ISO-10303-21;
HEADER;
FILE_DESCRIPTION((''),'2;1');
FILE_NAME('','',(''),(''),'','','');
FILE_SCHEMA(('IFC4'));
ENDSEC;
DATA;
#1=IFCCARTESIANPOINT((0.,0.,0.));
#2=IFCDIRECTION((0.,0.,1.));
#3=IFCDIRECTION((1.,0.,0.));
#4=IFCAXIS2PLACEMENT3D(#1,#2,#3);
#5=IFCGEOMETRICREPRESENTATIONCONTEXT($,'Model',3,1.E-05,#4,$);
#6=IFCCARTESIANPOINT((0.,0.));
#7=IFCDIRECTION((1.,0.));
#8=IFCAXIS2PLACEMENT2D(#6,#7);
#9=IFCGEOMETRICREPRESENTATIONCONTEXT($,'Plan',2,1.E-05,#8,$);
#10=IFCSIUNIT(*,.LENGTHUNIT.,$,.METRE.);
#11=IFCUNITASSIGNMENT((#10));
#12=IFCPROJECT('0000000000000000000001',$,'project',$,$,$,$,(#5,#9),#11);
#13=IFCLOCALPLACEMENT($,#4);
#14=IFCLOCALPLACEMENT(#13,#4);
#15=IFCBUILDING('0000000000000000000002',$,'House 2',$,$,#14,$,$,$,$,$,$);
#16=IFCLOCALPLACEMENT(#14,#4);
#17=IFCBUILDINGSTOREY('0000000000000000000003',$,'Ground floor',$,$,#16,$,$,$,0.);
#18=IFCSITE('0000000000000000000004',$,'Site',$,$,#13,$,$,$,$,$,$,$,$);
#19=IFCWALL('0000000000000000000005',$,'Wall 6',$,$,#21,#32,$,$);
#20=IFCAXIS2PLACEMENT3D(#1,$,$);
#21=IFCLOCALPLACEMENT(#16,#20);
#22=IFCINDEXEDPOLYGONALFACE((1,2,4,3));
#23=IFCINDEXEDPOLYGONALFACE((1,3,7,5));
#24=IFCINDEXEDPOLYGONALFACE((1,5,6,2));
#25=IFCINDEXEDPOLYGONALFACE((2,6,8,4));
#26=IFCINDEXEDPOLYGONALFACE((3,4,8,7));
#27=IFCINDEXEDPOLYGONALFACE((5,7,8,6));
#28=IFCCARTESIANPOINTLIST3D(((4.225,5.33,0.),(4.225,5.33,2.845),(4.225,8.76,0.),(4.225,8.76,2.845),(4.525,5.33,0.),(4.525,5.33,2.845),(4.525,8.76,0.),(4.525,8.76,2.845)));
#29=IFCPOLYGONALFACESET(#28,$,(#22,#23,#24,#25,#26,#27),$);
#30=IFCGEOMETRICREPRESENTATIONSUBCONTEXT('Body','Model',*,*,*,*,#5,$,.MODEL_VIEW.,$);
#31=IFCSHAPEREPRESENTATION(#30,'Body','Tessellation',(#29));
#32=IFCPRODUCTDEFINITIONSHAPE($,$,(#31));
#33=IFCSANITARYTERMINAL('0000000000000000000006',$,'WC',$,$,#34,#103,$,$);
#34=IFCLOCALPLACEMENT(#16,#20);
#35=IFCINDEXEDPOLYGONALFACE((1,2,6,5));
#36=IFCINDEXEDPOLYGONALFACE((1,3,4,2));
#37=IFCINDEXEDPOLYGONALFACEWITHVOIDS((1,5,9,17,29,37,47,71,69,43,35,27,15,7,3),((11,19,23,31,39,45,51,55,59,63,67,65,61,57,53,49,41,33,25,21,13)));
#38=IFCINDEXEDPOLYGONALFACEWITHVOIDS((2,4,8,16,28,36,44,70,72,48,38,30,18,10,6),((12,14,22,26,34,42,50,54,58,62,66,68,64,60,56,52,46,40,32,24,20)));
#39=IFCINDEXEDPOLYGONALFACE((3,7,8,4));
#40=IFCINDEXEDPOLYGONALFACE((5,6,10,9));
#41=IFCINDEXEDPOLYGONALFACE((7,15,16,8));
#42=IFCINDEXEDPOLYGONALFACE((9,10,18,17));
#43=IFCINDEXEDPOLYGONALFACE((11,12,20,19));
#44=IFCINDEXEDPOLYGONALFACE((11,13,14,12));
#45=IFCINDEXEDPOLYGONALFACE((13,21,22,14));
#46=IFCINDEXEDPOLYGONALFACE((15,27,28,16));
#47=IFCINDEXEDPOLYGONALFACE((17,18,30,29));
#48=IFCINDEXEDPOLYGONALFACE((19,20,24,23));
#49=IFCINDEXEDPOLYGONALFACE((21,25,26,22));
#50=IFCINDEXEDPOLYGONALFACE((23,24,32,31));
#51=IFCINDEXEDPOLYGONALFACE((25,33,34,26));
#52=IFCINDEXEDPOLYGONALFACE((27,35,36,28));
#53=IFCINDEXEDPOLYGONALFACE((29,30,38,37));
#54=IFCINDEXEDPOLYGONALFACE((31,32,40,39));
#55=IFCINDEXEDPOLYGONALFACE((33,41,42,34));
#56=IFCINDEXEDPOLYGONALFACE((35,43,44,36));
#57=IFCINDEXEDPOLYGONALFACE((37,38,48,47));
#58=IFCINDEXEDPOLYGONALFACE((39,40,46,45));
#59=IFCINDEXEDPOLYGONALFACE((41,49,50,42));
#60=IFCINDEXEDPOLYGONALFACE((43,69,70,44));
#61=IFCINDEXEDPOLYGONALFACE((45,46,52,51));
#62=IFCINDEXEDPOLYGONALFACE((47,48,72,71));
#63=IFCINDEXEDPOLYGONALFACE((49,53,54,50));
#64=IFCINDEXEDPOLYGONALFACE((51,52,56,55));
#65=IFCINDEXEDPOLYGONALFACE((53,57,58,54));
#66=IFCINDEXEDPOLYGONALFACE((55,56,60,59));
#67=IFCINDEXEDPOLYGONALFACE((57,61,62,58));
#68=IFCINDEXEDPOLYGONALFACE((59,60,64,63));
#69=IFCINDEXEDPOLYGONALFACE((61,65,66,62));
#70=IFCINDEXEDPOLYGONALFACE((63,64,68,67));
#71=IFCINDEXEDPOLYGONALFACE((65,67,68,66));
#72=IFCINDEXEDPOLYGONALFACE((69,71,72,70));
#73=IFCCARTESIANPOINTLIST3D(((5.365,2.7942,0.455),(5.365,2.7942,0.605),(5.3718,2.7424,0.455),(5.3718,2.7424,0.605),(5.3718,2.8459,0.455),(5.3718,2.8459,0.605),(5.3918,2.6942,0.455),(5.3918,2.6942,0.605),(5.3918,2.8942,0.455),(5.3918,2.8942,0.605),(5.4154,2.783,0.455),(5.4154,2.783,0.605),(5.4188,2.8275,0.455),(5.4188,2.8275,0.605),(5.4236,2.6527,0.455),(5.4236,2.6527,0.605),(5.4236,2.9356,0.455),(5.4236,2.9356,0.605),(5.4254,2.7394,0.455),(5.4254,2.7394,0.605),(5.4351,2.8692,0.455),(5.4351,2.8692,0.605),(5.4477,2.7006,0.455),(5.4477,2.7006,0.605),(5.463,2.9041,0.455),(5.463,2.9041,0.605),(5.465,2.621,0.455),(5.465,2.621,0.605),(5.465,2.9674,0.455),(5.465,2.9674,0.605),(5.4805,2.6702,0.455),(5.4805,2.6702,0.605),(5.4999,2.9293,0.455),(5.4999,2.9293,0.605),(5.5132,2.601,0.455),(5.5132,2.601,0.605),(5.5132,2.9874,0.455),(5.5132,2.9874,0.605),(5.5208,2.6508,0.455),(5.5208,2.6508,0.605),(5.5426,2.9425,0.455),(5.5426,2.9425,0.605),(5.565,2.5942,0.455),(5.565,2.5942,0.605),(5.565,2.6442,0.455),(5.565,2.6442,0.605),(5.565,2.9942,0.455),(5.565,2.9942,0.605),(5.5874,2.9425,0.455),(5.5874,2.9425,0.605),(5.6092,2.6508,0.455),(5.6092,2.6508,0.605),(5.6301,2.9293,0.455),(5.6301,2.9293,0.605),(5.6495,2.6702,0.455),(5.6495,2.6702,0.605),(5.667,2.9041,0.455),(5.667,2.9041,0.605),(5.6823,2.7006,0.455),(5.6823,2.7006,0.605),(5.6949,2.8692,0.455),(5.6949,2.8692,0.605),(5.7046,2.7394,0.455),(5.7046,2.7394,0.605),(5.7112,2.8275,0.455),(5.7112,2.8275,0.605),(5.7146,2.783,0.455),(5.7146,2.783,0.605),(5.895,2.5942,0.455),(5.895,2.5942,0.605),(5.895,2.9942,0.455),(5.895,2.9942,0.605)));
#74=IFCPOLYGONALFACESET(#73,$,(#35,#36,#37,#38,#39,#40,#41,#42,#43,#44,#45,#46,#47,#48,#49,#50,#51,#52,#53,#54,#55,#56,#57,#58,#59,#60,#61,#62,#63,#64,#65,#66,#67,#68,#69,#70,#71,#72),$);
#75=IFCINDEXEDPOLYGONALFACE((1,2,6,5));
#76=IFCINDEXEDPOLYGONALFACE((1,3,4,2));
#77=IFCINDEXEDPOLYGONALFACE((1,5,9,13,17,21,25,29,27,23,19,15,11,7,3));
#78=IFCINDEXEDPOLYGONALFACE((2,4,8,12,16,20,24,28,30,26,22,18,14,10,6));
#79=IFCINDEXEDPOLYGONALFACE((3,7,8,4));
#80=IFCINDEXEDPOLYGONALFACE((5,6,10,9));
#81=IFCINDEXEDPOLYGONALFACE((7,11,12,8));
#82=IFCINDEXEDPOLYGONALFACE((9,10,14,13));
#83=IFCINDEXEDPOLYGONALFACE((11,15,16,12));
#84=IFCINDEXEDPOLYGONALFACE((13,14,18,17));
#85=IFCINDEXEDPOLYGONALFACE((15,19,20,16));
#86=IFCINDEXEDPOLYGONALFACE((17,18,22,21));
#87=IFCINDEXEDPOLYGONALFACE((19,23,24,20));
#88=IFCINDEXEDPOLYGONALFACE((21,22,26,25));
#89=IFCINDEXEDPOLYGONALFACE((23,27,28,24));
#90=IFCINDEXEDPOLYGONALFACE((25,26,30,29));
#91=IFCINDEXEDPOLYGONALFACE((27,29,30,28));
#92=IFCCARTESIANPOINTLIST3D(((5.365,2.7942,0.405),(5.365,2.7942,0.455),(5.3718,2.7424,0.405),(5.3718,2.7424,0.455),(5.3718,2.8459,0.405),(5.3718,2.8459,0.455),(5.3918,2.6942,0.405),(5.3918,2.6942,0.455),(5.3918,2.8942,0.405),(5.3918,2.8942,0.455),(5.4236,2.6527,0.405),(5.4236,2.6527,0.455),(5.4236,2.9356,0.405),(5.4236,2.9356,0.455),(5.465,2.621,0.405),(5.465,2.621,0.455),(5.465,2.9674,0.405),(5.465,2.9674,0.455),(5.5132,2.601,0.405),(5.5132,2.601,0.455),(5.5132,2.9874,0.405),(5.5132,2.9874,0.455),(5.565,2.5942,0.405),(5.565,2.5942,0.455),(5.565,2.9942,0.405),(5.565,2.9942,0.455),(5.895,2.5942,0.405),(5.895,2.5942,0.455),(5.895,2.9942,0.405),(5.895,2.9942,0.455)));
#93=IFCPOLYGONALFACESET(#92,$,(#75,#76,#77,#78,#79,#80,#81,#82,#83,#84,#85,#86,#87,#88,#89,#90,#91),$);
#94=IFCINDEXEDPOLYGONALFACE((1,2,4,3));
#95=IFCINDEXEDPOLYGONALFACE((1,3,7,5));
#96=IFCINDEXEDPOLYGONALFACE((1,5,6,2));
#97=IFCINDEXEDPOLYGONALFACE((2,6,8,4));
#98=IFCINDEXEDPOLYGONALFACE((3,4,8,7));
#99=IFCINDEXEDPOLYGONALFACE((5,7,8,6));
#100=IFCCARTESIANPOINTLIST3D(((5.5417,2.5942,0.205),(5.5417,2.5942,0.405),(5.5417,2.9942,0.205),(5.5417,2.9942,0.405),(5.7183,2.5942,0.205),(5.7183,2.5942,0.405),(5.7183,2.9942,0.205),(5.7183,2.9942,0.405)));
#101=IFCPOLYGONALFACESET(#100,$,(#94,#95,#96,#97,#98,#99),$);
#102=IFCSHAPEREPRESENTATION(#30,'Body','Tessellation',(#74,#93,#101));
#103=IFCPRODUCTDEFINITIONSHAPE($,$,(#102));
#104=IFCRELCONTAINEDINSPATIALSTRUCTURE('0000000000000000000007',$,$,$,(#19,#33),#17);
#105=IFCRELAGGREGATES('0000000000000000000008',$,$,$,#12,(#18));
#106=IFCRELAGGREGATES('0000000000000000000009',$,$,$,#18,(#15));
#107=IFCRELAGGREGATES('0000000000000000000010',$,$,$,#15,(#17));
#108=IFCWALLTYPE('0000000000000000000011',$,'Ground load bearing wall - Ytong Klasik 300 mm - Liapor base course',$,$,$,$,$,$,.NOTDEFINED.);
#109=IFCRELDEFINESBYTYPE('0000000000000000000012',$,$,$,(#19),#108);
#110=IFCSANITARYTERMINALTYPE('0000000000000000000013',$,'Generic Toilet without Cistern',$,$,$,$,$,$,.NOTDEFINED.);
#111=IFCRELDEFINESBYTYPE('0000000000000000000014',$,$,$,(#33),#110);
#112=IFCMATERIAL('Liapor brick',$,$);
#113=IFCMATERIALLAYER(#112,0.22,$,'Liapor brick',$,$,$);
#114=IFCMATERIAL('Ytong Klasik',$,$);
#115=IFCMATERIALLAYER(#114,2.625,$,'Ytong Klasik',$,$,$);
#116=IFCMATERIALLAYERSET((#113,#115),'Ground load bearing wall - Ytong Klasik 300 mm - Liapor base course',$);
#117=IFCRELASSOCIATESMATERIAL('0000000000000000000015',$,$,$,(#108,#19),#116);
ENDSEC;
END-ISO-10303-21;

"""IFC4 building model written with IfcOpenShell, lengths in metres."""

from ifc_helpers import new_model, entity, si_unit, frame, frame_2d, origin_with_axes, origin_2d_with_axis, place, context, subcontext, project, spatial, line, arc, indexed_curve, circle_curve, outline, extrude, shape, source, transform, mapped, material, layer, layer_set, layer_usage, type_object, type_shapes, element, save


model = new_model("IFC4")

# Units and contexts
model_context = context("Model", 3, precision=1e-05, world=origin_with_axes())
plan_context = context("Plan", 2, precision=1e-05, world=origin_2d_with_axis())
body_context_1 = subcontext(model_context, "Body", "Model", "MODEL_VIEW")
body_context_2 = subcontext(plan_context, "Body", "Plan", "PLAN_VIEW")
ifc_project = project(units=[si_unit("LENGTHUNIT", "METRE")], contexts=[model_context, plan_context])

# Site, building, storey
site_placement = place(None, origin_with_axes())
site = spatial("IfcSite", under=ifc_project, at=site_placement, Name="Site")
building_placement = place(site_placement, origin_with_axes())
building = spatial("IfcBuilding", under=site, at=building_placement, Name="House 2")
storey_placement = place(building_placement, origin_with_axes())
storey = spatial("IfcBuildingStorey", under=building, at=storey_placement, Name="Ground floor", Elevation=0.0)

# Shared definitions
ifc_material_1 = material(Name="Liapor brick")

# Wall
ifc_layer_1 = layer(ifc_material_1, 0.22, Name="Liapor brick")
ifc_material_2 = material(Name="Ytong Klasik")
ifc_layer_2 = layer(ifc_material_2, 2.625, Name="Ytong Klasik")
ifc_layer_set_1 = layer_set([ifc_layer_1, ifc_layer_2], Name="Ground load bearing wall - Ytong Klasik 300 mm - Liapor base course")
ifc_layer_usage_1 = layer_usage(ifc_layer_set_1, "AXIS3", "POSITIVE", 0.0)
wall_type_1 = type_object("IfcWallType", Name="Ground load bearing wall - Ytong Klasik 300 mm - Liapor base course", PredefinedType="NOTDEFINED", material=ifc_layer_set_1)
wall_1_placement = place(storey_placement, frame((4.375, 5.33, 0.0), z_axis=(0.0, 0.0, 1.0), x_axis=(0.0, 1.0, 0.0)))
element("IfcWall", 1, at=wall_1_placement, inside=storey, type_object=wall_type_1, material=ifc_layer_usage_1, Name="Wall 6", context=body_context_1, shape_type="SweptSolid", body=[
    extrude(outline(indexed_curve([(0.0, 0.0), (0.0, 0.3), (3.43, 0.3), (3.43, 0.0), (0.0, 0.0)], self_intersect=False)), frame((0.0, -0.15, 0.0), z_axis=(0.0, 0.0, 1.0), x_axis=(1.0, 0.0, 0.0)), (0.0, 0.0, 1.0), 2.845),
])

# Sanitary terminal
sanitary_terminal_type_1 = type_object("IfcSanitaryTerminalType", Name="Generic Toilet without Cistern", PredefinedType="NOTDEFINED")
shared_shape_1 = source(origin_with_axes(), body_context_1, "Body", "SweptSolid", [
    extrude(outline(indexed_curve([(-0.2, 0.0), (0.2, 0.0), (0.2, -0.33), (0.1414, -0.4714), (0.0, -0.53), (-0.1414, -0.4714), (-0.2, -0.33)], segments=[line(1, 2), line(2, 3), arc(3, 4, 5), arc(5, 6, 7), line(7, 1)]), holes=[circle_curve(frame_2d((0.0, -0.33)), 0.15)]), frame((0.0, 0.0, 0.25), z_axis=(0.0, 0.0, 1.0), x_axis=(1.0, 0.0, 0.0)), (0.0, 0.0, 1.0), 0.15),
    extrude(outline(indexed_curve([(-0.2, 0.0), (0.2, 0.0), (0.2, -0.33), (0.1414, -0.4714), (0.0, -0.53), (-0.1414, -0.4714), (-0.2, -0.33)], segments=[line(1, 2), line(2, 3), arc(3, 4, 5), arc(5, 6, 7), line(7, 1)])), frame((0.0, 0.0, 0.2), z_axis=(0.0, 0.0, 1.0), x_axis=(1.0, 0.0, 0.0)), (0.0, 0.0, 1.0), 0.05),
    extrude(outline(indexed_curve([(-0.2, -0.1767), (0.2, -0.1767), (0.2, -0.3533), (-0.2, -0.3533)], segments=[line(1, 2, 3, 4, 1)])), origin_with_axes(), (0.0, 0.0, 1.0), 0.2),
])
shared_shape_2 = source(origin_with_axes(), body_context_2, "Body", "Curve2D", [
    entity("IfcIndexedPolyCurve", entity("IfcCartesianPointList2D", [[-0.12, 0.0], [0.12, 0.0]])),
    entity("IfcIndexedPolyCurve", entity("IfcCartesianPointList2D", [[0.12, 0.0], [0.2, -0.159]])),
    entity("IfcTrimmedCurve", entity("IfcEllipse", entity("IfcAxis2Placement2D", entity("IfcCartesianPoint", [0.0, -0.159]), entity("IfcDirection", [1.0, 0.0])), 0.2, 0.371), [entity("IfcCartesianPoint", [-0.2, -0.159])], [entity("IfcCartesianPoint", [0.2, -0.159])], True, "CARTESIAN"),
    entity("IfcIndexedPolyCurve", entity("IfcCartesianPointList2D", [[-0.12, 0.0], [-0.2, -0.159]])),
    entity("IfcEllipse", entity("IfcAxis2Placement2D", entity("IfcCartesianPoint", [0.0, -0.2968]), entity("IfcDirection", [1.0, 0.0])), 0.15, 0.1855),
    entity("IfcIndexedPolyCurve", entity("IfcCartesianPointList2D", [[-0.025, -0.2968], [-0.025, -0.2703], [0.025, -0.2703], [0.025, -0.2968]])),
    entity("IfcTrimmedCurve", entity("IfcEllipse", entity("IfcAxis2Placement2D", entity("IfcCartesianPoint", [0.0, -0.2968]), entity("IfcDirection", [1.0, 0.0])), 0.025, 0.0265), [entity("IfcCartesianPoint", [-0.025, -0.2968])], [entity("IfcCartesianPoint", [0.025, -0.2968])], True, "CARTESIAN"),
])
type_shapes(sanitary_terminal_type_1, [shared_shape_1, shared_shape_2])
sanitary_terminal_1_placement = place(storey_placement, frame((5.895, 2.7942, 0.205), z_axis=(0.0, 0.0, 1.0), x_axis=(0.0, -1.0, 0.0)))
element("IfcSanitaryTerminal", 2, at=sanitary_terminal_1_placement, inside=storey, type_object=sanitary_terminal_type_1, Name="WC", shapes=[
    shape(body_context_1, "Body", "MappedRepresentation", [mapped(shared_shape_1, transform((0.0, 0.0, 0.0), x_axis=(1.0, 0.0, 0.0), y_axis=(0.0, 1.0, 0.0), z_axis=(0.0, 0.0, 1.0), scale=1.0))]),
    shape(body_context_2, "Body", "MappedRepresentation", [mapped(shared_shape_2, transform((0.0, 0.0, 0.0), x_axis=(1.0, 0.0, 0.0), y_axis=(0.0, 1.0, 0.0), z_axis=(0.0, 0.0, 1.0), scale=1.0))]),
])

save(model, "model.ifc")
